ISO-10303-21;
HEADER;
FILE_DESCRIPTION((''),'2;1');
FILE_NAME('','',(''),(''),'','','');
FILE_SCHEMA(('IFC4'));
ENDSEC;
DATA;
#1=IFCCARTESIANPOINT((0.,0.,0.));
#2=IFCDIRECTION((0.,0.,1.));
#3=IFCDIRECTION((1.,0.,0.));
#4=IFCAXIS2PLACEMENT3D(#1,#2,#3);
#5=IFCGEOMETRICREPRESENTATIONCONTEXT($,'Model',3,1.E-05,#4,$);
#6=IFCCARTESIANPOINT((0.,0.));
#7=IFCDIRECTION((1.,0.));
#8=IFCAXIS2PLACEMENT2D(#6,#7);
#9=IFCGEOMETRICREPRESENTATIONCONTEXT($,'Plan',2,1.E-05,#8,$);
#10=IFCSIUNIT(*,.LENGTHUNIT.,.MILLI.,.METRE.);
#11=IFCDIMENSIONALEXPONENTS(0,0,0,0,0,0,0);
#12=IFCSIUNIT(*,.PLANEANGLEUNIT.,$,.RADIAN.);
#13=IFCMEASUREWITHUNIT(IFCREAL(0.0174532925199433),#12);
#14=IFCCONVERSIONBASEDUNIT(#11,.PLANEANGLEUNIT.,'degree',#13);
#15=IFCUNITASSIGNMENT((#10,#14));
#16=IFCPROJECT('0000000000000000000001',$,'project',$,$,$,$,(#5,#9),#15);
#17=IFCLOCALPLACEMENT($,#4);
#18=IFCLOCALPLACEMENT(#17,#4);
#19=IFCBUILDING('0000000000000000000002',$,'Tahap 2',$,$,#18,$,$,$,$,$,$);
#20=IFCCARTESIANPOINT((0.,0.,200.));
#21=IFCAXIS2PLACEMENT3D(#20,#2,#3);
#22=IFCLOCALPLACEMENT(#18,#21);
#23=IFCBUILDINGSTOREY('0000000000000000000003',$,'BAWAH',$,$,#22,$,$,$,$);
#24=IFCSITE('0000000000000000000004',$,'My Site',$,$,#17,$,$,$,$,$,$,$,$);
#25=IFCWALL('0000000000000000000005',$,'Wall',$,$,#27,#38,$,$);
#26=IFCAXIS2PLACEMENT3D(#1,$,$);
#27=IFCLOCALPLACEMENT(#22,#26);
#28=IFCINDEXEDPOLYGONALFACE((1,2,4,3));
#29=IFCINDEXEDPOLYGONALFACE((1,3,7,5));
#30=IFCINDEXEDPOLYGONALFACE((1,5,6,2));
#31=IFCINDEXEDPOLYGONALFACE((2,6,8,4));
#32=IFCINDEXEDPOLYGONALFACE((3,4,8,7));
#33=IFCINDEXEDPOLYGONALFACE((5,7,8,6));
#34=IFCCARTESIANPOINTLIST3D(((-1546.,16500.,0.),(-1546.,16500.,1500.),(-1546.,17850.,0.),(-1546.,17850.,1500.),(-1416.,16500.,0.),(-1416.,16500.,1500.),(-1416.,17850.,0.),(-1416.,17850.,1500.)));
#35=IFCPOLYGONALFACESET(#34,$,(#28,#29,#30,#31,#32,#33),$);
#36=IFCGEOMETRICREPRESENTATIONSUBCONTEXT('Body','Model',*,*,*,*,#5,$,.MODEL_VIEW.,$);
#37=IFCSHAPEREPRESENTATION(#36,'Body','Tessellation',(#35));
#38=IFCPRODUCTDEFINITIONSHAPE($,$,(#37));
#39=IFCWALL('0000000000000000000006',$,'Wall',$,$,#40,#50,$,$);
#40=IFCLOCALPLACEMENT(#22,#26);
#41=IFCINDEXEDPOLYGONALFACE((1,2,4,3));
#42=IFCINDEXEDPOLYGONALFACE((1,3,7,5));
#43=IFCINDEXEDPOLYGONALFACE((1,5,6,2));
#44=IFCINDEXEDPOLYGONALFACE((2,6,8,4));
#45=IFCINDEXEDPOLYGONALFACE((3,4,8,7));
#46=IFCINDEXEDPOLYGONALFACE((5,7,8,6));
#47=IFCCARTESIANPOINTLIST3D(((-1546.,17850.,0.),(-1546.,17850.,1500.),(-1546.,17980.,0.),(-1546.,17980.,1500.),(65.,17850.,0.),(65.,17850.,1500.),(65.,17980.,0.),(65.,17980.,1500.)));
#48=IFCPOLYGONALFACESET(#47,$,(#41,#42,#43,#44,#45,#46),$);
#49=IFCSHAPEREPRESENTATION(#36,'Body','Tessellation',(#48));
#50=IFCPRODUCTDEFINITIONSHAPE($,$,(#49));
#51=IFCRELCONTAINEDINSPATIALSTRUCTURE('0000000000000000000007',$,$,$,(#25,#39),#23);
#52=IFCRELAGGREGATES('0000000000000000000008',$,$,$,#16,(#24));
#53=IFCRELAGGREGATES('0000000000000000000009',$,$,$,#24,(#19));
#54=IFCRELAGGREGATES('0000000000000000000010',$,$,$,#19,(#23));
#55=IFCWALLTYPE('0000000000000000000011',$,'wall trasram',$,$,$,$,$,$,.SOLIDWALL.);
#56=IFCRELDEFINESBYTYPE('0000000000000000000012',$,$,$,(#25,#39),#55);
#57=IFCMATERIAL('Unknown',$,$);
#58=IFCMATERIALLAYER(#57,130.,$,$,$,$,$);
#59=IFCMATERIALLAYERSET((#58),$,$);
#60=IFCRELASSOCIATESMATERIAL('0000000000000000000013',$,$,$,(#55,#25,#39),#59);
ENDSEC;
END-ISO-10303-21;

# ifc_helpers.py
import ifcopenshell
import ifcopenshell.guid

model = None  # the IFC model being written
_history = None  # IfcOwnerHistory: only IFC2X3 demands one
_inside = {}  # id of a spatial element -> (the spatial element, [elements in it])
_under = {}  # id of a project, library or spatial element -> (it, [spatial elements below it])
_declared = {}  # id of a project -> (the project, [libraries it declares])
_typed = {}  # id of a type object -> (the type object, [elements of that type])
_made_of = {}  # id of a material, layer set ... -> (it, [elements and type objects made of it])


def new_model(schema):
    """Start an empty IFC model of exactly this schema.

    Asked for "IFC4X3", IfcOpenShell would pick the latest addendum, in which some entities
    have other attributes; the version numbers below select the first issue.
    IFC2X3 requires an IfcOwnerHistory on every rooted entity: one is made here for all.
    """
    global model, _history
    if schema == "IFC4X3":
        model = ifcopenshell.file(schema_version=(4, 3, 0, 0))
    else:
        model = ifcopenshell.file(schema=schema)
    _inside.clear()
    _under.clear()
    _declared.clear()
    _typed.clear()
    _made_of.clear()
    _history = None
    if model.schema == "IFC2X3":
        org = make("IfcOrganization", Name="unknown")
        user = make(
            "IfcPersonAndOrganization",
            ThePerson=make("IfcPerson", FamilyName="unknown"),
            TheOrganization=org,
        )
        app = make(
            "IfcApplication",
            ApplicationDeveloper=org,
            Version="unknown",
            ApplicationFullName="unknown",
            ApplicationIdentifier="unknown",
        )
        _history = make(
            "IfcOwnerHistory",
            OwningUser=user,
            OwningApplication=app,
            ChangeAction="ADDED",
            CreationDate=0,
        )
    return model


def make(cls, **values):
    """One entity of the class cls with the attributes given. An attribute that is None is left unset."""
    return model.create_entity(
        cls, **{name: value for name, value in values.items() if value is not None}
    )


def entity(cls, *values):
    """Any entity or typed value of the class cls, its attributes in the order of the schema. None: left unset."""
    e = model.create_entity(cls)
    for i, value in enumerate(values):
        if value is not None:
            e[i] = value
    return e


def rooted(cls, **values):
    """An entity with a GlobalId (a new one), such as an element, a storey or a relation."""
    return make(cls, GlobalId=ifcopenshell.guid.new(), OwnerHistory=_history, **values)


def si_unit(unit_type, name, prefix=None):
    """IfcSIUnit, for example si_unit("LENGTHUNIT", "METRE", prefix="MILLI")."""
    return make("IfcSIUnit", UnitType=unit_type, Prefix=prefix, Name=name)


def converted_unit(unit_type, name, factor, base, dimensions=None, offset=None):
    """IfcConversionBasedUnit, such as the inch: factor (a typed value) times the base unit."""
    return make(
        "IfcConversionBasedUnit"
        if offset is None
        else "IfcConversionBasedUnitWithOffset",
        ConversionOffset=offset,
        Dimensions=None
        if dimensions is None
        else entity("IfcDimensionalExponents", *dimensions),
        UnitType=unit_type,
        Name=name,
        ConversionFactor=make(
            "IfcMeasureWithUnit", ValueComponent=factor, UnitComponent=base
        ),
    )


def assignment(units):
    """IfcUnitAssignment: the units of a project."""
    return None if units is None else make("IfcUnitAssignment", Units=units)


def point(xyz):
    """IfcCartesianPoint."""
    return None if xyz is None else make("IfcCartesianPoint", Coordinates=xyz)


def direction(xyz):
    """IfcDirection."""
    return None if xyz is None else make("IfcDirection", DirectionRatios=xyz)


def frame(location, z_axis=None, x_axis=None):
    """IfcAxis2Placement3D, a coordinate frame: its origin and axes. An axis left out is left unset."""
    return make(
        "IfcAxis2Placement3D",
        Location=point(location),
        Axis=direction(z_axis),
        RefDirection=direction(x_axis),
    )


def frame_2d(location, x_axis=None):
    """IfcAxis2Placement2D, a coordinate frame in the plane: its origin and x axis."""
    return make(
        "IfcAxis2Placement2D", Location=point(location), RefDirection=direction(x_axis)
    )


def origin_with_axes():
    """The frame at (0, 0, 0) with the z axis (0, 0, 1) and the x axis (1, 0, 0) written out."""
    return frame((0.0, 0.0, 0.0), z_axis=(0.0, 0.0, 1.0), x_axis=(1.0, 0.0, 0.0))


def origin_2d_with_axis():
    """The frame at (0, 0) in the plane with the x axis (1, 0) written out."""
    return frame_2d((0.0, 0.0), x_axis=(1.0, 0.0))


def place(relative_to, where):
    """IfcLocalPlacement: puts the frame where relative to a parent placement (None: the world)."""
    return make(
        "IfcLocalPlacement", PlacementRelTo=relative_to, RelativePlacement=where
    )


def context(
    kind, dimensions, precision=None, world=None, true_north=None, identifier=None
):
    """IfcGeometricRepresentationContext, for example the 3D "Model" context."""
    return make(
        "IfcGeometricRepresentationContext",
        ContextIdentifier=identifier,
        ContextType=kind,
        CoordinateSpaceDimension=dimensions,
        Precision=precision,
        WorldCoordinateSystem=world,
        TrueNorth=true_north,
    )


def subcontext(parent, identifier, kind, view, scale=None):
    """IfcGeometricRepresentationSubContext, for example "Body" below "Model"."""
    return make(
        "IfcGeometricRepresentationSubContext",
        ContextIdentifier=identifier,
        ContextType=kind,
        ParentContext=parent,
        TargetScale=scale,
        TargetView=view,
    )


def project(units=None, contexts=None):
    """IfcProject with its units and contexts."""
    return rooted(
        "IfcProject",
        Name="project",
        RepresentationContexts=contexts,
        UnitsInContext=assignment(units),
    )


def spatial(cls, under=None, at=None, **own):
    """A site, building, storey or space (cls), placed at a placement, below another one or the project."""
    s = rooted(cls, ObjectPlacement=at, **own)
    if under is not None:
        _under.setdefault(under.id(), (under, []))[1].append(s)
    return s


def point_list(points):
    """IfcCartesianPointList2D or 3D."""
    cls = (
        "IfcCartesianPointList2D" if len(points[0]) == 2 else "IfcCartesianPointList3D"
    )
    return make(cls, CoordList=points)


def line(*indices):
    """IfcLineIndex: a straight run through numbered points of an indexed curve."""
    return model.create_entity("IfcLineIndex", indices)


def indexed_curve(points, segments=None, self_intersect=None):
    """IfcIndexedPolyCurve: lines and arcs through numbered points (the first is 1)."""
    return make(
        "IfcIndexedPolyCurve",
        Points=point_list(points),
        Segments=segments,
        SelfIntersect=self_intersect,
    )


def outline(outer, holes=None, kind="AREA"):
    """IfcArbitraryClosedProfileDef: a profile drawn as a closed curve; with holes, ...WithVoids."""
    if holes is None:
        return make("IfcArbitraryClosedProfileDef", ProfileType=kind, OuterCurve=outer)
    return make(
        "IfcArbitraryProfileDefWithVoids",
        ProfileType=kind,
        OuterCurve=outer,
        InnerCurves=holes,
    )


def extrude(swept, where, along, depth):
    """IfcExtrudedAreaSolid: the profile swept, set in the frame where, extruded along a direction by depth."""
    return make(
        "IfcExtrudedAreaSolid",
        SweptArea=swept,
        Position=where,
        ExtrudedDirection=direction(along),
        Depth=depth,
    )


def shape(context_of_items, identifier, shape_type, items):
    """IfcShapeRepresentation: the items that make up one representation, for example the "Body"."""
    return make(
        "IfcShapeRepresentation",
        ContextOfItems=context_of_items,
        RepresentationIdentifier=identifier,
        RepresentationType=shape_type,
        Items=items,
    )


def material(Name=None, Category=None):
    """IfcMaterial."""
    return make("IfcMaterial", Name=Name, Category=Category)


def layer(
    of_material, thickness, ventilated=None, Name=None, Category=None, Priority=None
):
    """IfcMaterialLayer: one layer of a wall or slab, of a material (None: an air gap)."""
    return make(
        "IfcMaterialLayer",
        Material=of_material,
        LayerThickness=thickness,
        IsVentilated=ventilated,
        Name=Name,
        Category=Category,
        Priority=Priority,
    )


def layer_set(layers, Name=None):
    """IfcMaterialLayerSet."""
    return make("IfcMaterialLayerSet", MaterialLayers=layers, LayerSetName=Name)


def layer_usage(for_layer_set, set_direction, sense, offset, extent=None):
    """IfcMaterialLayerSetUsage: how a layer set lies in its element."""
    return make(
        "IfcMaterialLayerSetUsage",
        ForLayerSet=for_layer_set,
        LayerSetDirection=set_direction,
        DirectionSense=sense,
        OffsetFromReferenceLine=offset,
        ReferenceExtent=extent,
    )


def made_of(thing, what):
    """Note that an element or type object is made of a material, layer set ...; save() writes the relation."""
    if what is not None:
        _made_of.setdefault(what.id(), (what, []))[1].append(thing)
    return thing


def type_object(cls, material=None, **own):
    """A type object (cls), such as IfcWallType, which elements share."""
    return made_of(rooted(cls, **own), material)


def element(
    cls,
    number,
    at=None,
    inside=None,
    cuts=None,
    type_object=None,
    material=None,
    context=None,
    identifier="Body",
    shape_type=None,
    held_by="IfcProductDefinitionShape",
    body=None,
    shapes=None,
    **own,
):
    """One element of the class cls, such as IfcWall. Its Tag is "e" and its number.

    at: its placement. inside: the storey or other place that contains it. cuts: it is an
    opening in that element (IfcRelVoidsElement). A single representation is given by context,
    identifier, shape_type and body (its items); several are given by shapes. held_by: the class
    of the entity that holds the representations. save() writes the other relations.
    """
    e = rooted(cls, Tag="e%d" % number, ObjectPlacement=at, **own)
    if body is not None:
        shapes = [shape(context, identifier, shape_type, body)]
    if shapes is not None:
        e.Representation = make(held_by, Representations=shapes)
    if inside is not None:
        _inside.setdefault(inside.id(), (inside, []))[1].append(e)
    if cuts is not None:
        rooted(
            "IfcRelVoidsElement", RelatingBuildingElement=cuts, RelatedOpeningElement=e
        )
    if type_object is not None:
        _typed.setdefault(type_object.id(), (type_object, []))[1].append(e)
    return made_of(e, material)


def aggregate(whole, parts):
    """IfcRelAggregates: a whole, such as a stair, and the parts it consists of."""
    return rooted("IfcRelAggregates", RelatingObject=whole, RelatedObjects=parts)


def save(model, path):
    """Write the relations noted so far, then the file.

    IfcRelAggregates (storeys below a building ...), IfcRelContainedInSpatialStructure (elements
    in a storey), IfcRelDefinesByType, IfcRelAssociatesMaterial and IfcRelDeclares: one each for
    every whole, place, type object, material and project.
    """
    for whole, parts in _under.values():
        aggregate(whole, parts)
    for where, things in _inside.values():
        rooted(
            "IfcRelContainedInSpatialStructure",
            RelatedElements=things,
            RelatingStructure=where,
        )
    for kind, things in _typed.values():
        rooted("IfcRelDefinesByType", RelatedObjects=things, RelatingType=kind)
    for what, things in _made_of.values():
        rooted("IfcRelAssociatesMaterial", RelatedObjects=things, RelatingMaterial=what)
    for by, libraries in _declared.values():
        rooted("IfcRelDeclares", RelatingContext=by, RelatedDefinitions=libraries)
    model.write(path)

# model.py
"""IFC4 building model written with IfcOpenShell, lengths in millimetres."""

from ifc_helpers import new_model, entity, si_unit, converted_unit, frame, origin_with_axes, origin_2d_with_axis, place, context, subcontext, project, spatial, line, indexed_curve, outline, extrude, material, layer, layer_set, layer_usage, type_object, element, save


model = new_model("IFC4")

# Units and contexts
model_context = context("Model", 3, precision=1e-05, world=origin_with_axes())
plan_context = context("Plan", 2, precision=1e-05, world=origin_2d_with_axis())
body_context_1 = subcontext(model_context, "Body", "Model", "MODEL_VIEW")
ifc_project = project(units=[si_unit("LENGTHUNIT", "METRE", prefix="MILLI"), converted_unit("PLANEANGLEUNIT", "degree", entity("IfcReal", 0.0174532925199433), si_unit("PLANEANGLEUNIT", "RADIAN"), dimensions=[0, 0, 0, 0, 0, 0, 0])], contexts=[model_context, plan_context])

# Site, building, storey
site_placement = place(None, origin_with_axes())
site = spatial("IfcSite", under=ifc_project, at=site_placement, Name="My Site")
building_placement = place(site_placement, origin_with_axes())
building = spatial("IfcBuilding", under=site, at=building_placement, Name="Tahap 2")
storey_placement = place(building_placement, frame((0.0, 0.0, 200.0), z_axis=(0.0, 0.0, 1.0), x_axis=(1.0, 0.0, 0.0)))
storey = spatial("IfcBuildingStorey", under=building, at=storey_placement, Name="BAWAH")

# Shared definitions
ifc_material_1 = material(Name="Unknown")

# Shared definitions
ifc_layer_1 = layer(ifc_material_1, 130.0)
ifc_layer_set_1 = layer_set([ifc_layer_1])
wall_type = type_object("IfcWallType", Name="wall trasram", PredefinedType="SOLIDWALL", material=ifc_layer_set_1)

# Walls
ifc_layer_usage_1 = layer_usage(ifc_layer_set_1, "AXIS2", "POSITIVE", 0.0)
wall_1_placement = place(storey_placement, frame((-1416.0, 16500.0, 0.0), z_axis=(0.0, 0.0, 1.0), x_axis=(0.0, 1.0, 0.0)))
element("IfcWall", 1, at=wall_1_placement, inside=storey, type_object=wall_type, material=ifc_layer_usage_1, Name="Wall", context=body_context_1, shape_type="SweptSolid", body=[
    extrude(outline(indexed_curve([(0.0, 0.0), (0.0, 130.0), (1350.0, 130.0), (1350.0, 0.0)], segments=[line(1, 2, 3, 4, 1)])), origin_with_axes(), (0.0, 0.0, 1.0), 1500.0),
])
ifc_layer_usage_2 = layer_usage(ifc_layer_set_1, "AXIS2", "POSITIVE", 0.0)
wall_2_placement = place(storey_placement, frame((65.0, 17980.0, 0.0), z_axis=(0.0, 0.0, 1.0), x_axis=(-1.0, -0.000001, 0.0)))
element("IfcWall", 2, at=wall_2_placement, inside=storey, type_object=wall_type, material=ifc_layer_usage_2, Name="Wall", context=body_context_1, shape_type="SweptSolid", body=[
    extrude(outline(indexed_curve([(0.0, 0.0), (0.0, 130.0), (1611.0, 130.0), (1611.0, 0.0)], segments=[line(1, 2, 3, 4, 1)])), origin_with_axes(), (0.0, 0.0, 1.0), 1500.0),
])

save(model, "model.ifc")
